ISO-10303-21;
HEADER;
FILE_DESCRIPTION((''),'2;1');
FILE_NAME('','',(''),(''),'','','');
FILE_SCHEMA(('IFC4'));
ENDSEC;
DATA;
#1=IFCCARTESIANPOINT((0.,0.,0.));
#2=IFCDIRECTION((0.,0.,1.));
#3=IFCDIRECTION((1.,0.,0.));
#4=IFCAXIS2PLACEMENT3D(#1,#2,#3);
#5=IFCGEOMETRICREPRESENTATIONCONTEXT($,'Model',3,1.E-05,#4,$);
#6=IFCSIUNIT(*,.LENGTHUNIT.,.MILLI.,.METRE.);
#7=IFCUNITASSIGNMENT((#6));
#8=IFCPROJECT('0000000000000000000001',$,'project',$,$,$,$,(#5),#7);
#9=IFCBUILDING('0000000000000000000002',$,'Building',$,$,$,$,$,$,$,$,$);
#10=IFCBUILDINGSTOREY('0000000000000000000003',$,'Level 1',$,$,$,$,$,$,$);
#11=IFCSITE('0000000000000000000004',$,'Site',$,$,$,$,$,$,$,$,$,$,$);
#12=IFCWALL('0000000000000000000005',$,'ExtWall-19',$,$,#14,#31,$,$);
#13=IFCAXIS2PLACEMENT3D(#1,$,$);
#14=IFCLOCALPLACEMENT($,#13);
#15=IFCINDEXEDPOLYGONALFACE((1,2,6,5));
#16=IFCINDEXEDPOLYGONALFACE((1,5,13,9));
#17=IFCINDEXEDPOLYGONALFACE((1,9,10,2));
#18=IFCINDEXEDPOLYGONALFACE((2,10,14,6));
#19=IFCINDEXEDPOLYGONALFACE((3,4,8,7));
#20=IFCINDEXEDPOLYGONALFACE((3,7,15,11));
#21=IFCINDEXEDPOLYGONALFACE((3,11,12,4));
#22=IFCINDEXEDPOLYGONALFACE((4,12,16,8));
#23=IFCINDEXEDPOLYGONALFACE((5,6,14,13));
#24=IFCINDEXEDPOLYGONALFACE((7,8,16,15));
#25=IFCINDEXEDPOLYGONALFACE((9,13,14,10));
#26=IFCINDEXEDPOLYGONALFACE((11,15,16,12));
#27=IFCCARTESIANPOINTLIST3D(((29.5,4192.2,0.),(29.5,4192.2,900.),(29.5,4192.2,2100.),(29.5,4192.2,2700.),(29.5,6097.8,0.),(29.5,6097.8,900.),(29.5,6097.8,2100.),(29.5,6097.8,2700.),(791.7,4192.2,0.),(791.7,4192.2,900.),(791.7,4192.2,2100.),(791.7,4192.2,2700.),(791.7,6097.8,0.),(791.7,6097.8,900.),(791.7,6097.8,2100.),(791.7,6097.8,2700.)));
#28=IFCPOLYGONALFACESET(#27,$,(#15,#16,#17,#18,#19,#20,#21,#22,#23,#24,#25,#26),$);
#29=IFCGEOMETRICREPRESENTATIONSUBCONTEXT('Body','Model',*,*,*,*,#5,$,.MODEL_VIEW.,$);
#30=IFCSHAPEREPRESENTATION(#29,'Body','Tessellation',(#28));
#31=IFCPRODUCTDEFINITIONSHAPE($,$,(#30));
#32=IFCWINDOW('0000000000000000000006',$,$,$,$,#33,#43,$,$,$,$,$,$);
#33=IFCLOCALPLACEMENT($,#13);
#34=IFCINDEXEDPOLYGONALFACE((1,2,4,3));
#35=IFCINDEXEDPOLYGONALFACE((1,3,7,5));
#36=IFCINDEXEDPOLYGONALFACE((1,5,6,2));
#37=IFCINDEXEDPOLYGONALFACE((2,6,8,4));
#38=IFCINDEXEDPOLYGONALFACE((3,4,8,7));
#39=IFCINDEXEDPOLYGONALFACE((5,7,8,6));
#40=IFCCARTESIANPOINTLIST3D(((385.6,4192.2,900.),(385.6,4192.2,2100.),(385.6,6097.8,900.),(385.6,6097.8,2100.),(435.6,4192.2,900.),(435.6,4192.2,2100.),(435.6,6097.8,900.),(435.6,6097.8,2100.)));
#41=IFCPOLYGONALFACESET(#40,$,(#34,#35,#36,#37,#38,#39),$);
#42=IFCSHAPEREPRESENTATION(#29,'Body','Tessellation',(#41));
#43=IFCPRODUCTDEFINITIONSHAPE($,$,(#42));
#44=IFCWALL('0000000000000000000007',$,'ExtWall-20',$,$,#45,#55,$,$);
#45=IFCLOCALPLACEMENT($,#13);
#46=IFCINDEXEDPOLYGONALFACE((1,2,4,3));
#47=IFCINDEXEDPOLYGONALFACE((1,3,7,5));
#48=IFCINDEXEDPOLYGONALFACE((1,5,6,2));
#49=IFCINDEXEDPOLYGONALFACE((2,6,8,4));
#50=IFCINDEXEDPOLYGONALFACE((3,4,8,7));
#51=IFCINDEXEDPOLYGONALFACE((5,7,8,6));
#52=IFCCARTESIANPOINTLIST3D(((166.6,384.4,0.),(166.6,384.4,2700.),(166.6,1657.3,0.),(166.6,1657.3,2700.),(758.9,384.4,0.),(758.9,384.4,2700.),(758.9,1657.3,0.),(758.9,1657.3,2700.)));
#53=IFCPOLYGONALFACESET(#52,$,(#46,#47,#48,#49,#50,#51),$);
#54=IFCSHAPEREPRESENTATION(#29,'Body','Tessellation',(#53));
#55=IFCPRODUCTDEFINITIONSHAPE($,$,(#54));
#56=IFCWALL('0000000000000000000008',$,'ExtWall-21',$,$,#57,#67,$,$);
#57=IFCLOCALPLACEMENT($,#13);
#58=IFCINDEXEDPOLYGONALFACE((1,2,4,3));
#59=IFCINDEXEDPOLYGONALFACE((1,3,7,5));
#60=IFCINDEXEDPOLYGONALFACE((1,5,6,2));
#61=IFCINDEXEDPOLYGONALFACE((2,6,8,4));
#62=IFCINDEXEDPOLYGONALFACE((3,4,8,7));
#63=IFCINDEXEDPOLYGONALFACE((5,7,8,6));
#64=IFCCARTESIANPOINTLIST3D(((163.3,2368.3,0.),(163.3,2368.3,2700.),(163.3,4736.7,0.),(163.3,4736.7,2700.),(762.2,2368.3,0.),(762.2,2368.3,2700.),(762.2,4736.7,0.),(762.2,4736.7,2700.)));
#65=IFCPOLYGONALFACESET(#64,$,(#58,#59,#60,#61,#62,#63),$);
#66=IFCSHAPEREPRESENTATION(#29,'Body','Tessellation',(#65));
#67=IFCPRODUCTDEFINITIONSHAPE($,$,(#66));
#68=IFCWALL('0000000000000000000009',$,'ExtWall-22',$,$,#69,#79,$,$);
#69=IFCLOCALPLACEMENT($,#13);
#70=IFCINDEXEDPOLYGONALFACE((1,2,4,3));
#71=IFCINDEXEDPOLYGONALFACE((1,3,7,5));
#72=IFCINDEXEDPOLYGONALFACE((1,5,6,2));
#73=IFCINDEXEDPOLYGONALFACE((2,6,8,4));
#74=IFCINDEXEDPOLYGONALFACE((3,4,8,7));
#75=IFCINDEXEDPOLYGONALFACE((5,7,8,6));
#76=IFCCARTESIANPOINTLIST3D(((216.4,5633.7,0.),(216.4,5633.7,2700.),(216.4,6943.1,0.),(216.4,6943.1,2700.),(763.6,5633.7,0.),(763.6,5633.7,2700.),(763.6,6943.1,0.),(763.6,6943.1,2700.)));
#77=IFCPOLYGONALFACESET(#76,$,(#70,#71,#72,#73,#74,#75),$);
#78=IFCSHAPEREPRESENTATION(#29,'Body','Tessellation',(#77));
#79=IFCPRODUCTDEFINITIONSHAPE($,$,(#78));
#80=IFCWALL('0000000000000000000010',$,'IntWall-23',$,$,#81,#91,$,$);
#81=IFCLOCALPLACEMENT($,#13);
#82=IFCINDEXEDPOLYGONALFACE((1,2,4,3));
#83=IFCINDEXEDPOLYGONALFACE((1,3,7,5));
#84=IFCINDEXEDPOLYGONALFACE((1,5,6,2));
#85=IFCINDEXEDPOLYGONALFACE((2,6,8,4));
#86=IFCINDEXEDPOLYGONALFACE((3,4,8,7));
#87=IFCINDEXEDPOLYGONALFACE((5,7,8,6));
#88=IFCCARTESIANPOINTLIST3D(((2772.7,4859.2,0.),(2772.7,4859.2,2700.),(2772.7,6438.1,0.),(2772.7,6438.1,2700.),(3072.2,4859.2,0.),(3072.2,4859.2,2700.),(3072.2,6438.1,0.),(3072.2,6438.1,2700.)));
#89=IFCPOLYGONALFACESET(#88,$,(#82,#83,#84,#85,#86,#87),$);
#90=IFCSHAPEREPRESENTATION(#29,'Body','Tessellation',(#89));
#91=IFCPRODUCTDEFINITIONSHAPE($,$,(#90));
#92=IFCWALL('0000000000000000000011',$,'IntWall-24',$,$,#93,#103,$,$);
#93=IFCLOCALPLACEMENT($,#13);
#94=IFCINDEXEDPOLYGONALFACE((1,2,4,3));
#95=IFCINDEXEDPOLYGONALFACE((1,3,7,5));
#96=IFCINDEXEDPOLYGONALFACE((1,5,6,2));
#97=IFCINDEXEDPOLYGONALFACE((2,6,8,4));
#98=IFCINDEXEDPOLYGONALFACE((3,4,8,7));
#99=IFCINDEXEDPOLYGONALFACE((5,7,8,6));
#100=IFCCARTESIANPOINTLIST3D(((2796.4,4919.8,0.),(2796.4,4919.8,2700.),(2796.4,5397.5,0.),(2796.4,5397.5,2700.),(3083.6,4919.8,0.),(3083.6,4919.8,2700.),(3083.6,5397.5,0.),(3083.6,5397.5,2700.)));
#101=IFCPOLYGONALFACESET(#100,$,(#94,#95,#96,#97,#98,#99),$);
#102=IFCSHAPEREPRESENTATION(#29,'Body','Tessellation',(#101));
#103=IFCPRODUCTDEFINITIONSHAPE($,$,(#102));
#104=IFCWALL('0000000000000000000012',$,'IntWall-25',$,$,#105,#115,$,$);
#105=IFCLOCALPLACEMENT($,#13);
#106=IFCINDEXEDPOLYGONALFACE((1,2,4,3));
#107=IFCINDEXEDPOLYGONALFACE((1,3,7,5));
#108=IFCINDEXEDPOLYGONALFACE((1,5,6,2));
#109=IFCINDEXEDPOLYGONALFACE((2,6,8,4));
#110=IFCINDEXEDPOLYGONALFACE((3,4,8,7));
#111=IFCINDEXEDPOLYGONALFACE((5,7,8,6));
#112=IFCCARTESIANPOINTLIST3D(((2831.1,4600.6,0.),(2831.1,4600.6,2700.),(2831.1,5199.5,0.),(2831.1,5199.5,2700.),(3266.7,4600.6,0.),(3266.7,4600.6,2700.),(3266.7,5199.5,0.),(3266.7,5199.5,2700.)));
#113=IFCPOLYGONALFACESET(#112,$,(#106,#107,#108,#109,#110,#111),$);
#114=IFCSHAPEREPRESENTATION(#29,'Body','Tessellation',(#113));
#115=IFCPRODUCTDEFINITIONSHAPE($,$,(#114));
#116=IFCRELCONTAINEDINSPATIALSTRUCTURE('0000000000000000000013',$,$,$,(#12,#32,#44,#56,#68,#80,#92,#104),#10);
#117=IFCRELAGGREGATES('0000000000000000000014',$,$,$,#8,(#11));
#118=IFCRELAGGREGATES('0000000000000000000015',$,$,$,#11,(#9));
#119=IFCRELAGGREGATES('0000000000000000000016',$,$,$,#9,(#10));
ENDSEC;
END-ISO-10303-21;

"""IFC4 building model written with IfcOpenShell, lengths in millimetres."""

from ifc_helpers import new_model, si_unit, frame, origin_with_axes, place, context, subcontext, project, spatial, indexed_curve, outline, extrude, element, fill, save


model = new_model("IFC4")

# Units and contexts
model_context = context("Model", 3, precision=1e-05, world=origin_with_axes())
body_context = subcontext(model_context, "Body", "Model", "MODEL_VIEW")
ifc_project = project(units=[si_unit("LENGTHUNIT", "METRE", prefix="MILLI")], contexts=[model_context])

# Site, building, storey
site = spatial("IfcSite", under=ifc_project, Name="Site")
building = spatial("IfcBuilding", under=site, Name="Building")
storey = spatial("IfcBuildingStorey", under=building, Name="Level 1")

# Wall, opening, window
wall_1_placement = place(None, frame((410.6, 4192.2, 0.0), z_axis=(0.0, 0.0, 1.0), x_axis=(0.0, 1.0, 0.0)))
wall_1 = element("IfcWall", 1, at=wall_1_placement, inside=storey, Name="ExtWall-19", context=body_context, shape_type="SweptSolid", body=[
    extrude(outline(indexed_curve([(0.0, 0.0), (0.0, 762.2), (1905.6, 762.2), (1905.6, 0.0), (0.0, 0.0)], self_intersect=False)), frame((0.0, -381.1, 0.0), z_axis=(0.0, 0.0, 1.0), x_axis=(1.0, 0.0, 0.0)), (0.0, 0.0, 1.0), 2700.0),
])
opening_1_placement = place(wall_1_placement, frame((0.0, 0.0, 900.0), z_axis=(0.0, 0.0, 1.0), x_axis=(1.0, 0.0, 0.0)))
opening_1 = element("IfcOpeningElement", 2, at=opening_1_placement, cuts=wall_1, context=body_context, shape_type="SweptSolid", body=[
    extrude(outline(indexed_curve([(0.0, 0.0), (0.0, 862.2), (1905.6, 862.2), (1905.6, 0.0), (0.0, 0.0)], self_intersect=False)), frame((0.0, -431.1, 0.0), z_axis=(0.0, 0.0, 1.0), x_axis=(1.0, 0.0, 0.0)), (0.0, 0.0, 1.0), 1200.0),
])
window_1_placement = place(opening_1_placement, origin_with_axes())
window_1 = element("IfcWindow", 3, at=window_1_placement, inside=storey, context=body_context, shape_type="SweptSolid", body=[
    extrude(outline(indexed_curve([(0.0, 0.0), (0.0, 50.0), (1905.6, 50.0), (1905.6, 0.0), (0.0, 0.0)], self_intersect=False)), frame((0.0, -25.0, 0.0), z_axis=(0.0, 0.0, 1.0), x_axis=(1.0, 0.0, 0.0)), (0.0, 0.0, 1.0), 1200.0),
])
fill(opening_1, window_1)

# Walls
wall_2_placement = place(None, frame((462.8, 384.4, 0.0), z_axis=(0.0, 0.0, 1.0), x_axis=(0.0, 1.0, 0.0)))
element("IfcWall", 4, at=wall_2_placement, inside=storey, Name="ExtWall-20", context=body_context, shape_type="SweptSolid", body=[
    extrude(outline(indexed_curve([(0.0, 0.0), (0.0, 592.3), (1272.8, 592.3), (1272.8, 0.0), (0.0, 0.0)], self_intersect=False)), frame((0.0, -296.1, 0.0), z_axis=(0.0, 0.0, 1.0), x_axis=(1.0, 0.0, 0.0)), (0.0, 0.0, 1.0), 2700.0),
])
wall_3_placement = place(None, frame((462.8, 2368.3, 0.0), z_axis=(0.0, 0.0, 1.0), x_axis=(0.0, 1.0, 0.0)))
element("IfcWall", 5, at=wall_3_placement, inside=storey, Name="ExtWall-21", context=body_context, shape_type="SweptSolid", body=[
    extrude(outline(indexed_curve([(0.0, 0.0), (0.0, 598.9), (2368.3, 598.9), (2368.3, 0.0), (0.0, 0.0)], self_intersect=False)), frame((0.0, -299.4, 0.0), z_axis=(0.0, 0.0, 1.0), x_axis=(1.0, 0.0, 0.0)), (0.0, 0.0, 1.0), 2700.0),
])
wall_4_placement = place(None, frame((490.0, 5633.7, 0.0), z_axis=(0.0, 0.0, 1.0), x_axis=(0.0, 1.0, 0.0)))
element("IfcWall", 6, at=wall_4_placement, inside=storey, Name="ExtWall-22", context=body_context, shape_type="SweptSolid", body=[
    extrude(outline(indexed_curve([(0.0, 0.0), (0.0, 547.2), (1309.4, 547.2), (1309.4, 0.0), (0.0, 0.0)], self_intersect=False)), frame((0.0, -273.6, 0.0), z_axis=(0.0, 0.0, 1.0), x_axis=(1.0, 0.0, 0.0)), (0.0, 0.0, 1.0), 2700.0),
])
wall_5_placement = place(None, frame((2922.5, 4859.2, 0.0), z_axis=(0.0, 0.0, 1.0), x_axis=(0.0, 1.0, 0.0)))
element("IfcWall", 7, at=wall_5_placement, inside=storey, Name="IntWall-23", context=body_context, shape_type="SweptSolid", body=[
    extrude(outline(indexed_curve([(0.0, 0.0), (0.0, 299.4), (1578.9, 299.4), (1578.9, 0.0), (0.0, 0.0)], self_intersect=False)), frame((0.0, -149.7, 0.0), z_axis=(0.0, 0.0, 1.0), x_axis=(1.0, 0.0, 0.0)), (0.0, 0.0, 1.0), 2700.0),
])
wall_6_placement = place(None, frame((2940.0, 4919.8, 0.0), z_axis=(0.0, 0.0, 1.0), x_axis=(0.0, 1.0, 0.0)))
element("IfcWall", 8, at=wall_6_placement, inside=storey, Name="IntWall-24", context=body_context, shape_type="SweptSolid", body=[
    extrude(outline(indexed_curve([(0.0, 0.0), (0.0, 287.2), (477.8, 287.2), (477.8, 0.0), (0.0, 0.0)], self_intersect=False)), frame((0.0, -143.6, 0.0), z_axis=(0.0, 0.0, 1.0), x_axis=(1.0, 0.0, 0.0)), (0.0, 0.0, 1.0), 2700.0),
])
wall_7_placement = place(None, frame((3048.9, 4600.6, 0.0), z_axis=(0.0, 0.0, 1.0), x_axis=(0.0, 1.0, 0.0)))
element("IfcWall", 9, at=wall_7_placement, inside=storey, Name="IntWall-25", context=body_context, shape_type="SweptSolid", body=[
    extrude(outline(indexed_curve([(0.0, 0.0), (0.0, 435.6), (598.9, 435.6), (598.9, 0.0), (0.0, 0.0)], self_intersect=False)), frame((0.0, -217.8, 0.0), z_axis=(0.0, 0.0, 1.0), x_axis=(1.0, 0.0, 0.0)), (0.0, 0.0, 1.0), 2700.0),
])

save(model, "model.ifc")
